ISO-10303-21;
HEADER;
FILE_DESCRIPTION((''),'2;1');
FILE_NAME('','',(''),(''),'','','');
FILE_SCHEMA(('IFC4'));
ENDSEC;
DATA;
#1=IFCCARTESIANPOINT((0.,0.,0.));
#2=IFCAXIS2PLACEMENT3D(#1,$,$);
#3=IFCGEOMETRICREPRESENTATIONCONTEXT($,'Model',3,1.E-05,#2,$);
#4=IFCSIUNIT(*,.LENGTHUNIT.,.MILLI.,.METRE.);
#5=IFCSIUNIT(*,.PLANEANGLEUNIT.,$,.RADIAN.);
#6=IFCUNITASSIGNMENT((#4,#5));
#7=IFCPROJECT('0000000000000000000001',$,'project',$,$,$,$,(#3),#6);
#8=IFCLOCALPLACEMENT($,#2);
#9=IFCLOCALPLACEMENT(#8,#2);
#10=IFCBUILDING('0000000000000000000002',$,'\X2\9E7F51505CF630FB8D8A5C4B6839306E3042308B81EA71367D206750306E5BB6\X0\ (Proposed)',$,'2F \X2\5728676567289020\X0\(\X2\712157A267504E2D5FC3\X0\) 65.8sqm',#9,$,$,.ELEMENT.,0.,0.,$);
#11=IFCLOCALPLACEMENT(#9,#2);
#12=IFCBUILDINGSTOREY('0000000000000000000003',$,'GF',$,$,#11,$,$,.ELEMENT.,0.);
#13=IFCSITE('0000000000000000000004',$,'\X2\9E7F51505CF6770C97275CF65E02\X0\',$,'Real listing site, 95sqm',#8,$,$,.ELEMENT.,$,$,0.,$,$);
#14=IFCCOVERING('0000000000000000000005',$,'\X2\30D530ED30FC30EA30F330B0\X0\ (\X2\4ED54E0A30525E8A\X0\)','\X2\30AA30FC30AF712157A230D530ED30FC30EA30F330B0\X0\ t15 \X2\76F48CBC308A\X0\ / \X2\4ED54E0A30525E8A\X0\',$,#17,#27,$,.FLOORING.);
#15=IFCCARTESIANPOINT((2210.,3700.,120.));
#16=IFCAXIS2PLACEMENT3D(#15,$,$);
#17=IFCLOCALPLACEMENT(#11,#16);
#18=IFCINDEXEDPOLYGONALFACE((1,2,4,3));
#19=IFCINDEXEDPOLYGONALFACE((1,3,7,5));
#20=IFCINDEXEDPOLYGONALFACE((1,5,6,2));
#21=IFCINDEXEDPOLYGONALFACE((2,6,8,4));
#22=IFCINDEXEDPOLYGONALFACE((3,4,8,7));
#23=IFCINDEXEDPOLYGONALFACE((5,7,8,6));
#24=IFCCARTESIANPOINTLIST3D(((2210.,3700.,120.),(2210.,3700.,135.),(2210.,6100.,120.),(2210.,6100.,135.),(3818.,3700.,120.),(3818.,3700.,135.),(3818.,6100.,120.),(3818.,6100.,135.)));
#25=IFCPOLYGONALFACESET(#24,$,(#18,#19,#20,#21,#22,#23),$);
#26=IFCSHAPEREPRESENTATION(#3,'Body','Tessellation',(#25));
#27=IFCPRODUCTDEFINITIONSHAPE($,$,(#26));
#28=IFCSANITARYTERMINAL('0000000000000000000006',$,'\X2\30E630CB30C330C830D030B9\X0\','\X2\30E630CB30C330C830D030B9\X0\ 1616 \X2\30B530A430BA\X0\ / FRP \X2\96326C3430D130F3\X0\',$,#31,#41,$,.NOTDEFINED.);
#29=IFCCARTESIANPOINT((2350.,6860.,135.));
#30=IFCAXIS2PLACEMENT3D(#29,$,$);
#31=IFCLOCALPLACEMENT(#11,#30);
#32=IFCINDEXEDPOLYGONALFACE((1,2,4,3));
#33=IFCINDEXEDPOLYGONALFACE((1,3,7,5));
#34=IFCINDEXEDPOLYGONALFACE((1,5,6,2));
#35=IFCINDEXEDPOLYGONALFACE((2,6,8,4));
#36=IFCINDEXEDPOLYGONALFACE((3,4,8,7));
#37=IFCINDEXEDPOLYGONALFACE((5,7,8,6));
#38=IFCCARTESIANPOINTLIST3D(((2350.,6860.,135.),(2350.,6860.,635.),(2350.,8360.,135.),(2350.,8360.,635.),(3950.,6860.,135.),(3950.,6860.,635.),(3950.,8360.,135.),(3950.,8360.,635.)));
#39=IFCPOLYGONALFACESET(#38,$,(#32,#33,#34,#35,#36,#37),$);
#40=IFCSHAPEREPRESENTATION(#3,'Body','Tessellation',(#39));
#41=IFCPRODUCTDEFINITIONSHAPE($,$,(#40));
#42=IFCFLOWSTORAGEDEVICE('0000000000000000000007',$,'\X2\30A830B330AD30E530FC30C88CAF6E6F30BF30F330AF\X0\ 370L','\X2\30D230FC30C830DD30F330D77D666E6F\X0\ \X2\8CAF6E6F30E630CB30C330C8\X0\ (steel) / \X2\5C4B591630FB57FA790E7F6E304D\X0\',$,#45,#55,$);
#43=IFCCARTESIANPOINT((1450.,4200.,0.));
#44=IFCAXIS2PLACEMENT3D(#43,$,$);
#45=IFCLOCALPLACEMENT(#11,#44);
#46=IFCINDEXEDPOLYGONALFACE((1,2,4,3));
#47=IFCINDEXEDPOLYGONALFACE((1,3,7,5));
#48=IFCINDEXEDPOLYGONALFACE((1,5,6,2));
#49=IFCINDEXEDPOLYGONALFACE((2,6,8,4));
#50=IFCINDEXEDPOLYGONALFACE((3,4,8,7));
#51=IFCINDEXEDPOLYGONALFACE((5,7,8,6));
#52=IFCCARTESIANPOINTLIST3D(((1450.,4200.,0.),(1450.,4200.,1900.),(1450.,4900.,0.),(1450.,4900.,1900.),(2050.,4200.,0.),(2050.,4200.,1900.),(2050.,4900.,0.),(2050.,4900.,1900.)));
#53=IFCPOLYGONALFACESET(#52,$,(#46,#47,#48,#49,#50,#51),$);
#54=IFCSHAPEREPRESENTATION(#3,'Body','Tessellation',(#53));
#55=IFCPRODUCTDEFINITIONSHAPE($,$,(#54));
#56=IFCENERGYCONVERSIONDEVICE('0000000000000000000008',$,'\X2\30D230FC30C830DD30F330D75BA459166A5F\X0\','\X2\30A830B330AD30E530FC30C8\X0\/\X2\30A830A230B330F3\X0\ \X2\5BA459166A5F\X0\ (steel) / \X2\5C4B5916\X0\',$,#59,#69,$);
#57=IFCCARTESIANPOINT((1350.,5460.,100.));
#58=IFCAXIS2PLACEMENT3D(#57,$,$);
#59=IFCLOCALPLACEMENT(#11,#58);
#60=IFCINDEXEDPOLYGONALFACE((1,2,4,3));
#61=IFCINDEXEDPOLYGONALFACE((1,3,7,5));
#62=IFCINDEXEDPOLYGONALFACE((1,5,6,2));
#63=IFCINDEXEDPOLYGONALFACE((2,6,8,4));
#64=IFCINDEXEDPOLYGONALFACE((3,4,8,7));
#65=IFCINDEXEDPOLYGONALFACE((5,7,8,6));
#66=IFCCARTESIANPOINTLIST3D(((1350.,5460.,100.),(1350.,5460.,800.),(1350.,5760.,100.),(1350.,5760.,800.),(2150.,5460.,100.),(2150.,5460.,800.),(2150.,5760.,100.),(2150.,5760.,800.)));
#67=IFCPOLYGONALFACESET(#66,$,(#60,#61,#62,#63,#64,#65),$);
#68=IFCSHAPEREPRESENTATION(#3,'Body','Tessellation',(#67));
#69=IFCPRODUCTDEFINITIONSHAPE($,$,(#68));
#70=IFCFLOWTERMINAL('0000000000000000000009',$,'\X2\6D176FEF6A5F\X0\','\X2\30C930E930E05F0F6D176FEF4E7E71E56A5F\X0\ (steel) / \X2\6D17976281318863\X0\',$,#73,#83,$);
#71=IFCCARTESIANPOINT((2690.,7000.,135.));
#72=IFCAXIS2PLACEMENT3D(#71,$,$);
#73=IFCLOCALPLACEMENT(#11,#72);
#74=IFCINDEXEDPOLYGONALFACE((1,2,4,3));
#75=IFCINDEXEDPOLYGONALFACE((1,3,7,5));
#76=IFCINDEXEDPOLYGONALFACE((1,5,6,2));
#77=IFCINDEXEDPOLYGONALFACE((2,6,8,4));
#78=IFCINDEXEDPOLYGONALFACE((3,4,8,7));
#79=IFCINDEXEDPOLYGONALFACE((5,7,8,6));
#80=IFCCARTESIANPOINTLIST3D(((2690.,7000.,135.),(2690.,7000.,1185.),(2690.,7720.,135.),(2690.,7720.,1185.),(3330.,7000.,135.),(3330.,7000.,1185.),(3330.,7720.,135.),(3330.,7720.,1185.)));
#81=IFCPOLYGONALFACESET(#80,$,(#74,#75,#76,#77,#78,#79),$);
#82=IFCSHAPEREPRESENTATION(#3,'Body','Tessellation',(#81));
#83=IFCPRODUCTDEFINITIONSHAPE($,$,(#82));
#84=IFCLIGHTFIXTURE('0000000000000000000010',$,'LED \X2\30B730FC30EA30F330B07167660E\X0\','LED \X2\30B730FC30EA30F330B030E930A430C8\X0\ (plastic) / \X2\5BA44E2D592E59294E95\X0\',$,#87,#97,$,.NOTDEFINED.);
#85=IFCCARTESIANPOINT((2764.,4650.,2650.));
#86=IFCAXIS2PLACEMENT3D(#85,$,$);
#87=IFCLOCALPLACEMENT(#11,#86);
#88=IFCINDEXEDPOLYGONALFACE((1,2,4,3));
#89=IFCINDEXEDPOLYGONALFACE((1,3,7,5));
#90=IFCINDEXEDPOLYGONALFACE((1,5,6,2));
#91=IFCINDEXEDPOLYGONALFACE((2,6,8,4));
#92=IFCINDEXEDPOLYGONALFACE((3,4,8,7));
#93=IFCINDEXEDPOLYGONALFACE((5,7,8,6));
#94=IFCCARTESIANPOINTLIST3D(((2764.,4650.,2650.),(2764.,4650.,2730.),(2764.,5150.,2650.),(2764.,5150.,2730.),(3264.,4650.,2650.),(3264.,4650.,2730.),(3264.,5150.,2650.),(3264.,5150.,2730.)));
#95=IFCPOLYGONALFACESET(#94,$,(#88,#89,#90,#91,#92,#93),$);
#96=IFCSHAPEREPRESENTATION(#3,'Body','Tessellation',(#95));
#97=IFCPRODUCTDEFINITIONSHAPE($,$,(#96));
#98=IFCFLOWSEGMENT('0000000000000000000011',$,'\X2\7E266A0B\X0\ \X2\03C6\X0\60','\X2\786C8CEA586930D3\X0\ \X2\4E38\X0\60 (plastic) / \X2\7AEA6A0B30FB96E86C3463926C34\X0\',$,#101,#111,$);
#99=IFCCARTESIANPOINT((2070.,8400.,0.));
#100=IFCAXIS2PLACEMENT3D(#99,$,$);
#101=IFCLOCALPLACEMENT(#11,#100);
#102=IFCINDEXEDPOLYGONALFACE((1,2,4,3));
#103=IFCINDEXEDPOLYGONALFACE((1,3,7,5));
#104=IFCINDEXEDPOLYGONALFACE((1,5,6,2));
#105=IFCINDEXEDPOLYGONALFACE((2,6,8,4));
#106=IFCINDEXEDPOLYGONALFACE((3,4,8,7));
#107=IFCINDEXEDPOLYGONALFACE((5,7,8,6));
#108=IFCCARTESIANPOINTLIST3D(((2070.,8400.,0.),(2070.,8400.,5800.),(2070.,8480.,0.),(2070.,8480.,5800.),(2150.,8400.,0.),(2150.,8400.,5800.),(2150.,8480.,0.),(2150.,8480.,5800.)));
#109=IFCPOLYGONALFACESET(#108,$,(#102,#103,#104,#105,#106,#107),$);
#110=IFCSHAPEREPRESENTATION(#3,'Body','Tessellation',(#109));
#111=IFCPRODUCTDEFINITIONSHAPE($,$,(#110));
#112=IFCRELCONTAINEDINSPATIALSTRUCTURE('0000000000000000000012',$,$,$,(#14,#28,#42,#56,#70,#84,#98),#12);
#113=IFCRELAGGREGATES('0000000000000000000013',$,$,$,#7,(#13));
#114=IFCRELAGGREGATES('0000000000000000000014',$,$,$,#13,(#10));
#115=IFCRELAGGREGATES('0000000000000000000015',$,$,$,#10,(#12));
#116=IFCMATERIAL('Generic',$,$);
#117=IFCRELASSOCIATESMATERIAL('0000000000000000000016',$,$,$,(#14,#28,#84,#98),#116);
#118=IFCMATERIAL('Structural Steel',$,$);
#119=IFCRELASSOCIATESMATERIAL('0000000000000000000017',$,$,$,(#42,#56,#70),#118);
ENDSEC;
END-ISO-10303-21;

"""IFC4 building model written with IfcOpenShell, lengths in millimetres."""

from ifc_helpers import new_model, si_unit, frame, frame_2d, origin, place, context, project, spatial, rectangle, extrude, material, element, save


model = new_model("IFC4")

# Units and contexts
model_context = context("Model", 3, precision=1e-05, world=origin())
ifc_project = project(units=[si_unit("LENGTHUNIT", "METRE", prefix="MILLI"), si_unit("PLANEANGLEUNIT", "RADIAN")], contexts=[model_context])

# Site, building, storey
site_placement = place(None, origin())
site = spatial("IfcSite", under=ifc_project, at=site_placement, Name="鹿児島県霧島市", ObjectType="Real listing site, 95sqm", CompositionType="ELEMENT", RefElevation=0.0)
building_placement = place(site_placement, origin())
building = spatial("IfcBuilding", under=site, at=building_placement, Name="鹿児島・越屋根のある自然素材の家 (Proposed)", ObjectType="2F 在来木造(無垢材中心) 65.8sqm", CompositionType="ELEMENT", ElevationOfRefHeight=0.0, ElevationOfTerrain=0.0)
storey_placement = place(building_placement, origin())
storey = spatial("IfcBuildingStorey", under=building, at=storey_placement, Name="GF", CompositionType="ELEMENT", Elevation=0.0)

# Covering
ifc_material_1 = material(Name="Generic")
covering_1_placement = place(storey_placement, frame((2210.0, 3700.0, 120.0)))
element("IfcCovering", 1, at=covering_1_placement, inside=storey, material=ifc_material_1, Name="フローリング (仕上げ床)", Description="オーク無垢フローリング t15 直貼り / 仕上げ床", PredefinedType="FLOORING", context=model_context, shape_type="SweptSolid", body=[
    extrude(rectangle(XDim=1608.0, YDim=2400.0, at=frame_2d((804.0, 1200.0))), frame((2210.0, 3700.0, 120.0)), (0.0, 0.0, 1.0), 15.0),
])

# Sanitary terminal
sanitary_terminal_placement = place(storey_placement, frame((2350.0, 6860.0, 135.0)))
element("IfcSanitaryTerminal", 2, at=sanitary_terminal_placement, inside=storey, material=ifc_material_1, Name="ユニットバス", Description="ユニットバス 1616 サイズ / FRP 防水パン", PredefinedType="NOTDEFINED", context=model_context, shape_type="SweptSolid", body=[
    extrude(rectangle(XDim=1600.0, YDim=1500.0, at=frame_2d((800.0, 750.0))), frame((2350.0, 6860.0, 135.0)), (0.0, 0.0, 1.0), 500.0),
])

# Flow storage device
ifc_material_2 = material(Name="Structural Steel")
flow_storage_device_placement = place(storey_placement, frame((1450.0, 4200.0, 0.0)))
element("IfcFlowStorageDevice", 3, at=flow_storage_device_placement, inside=storey, material=ifc_material_2, Name="エコキュート貯湯タンク 370L", Description="ヒートポンプ給湯 貯湯ユニット (steel) / 屋外・基礎置き", context=model_context, shape_type="SweptSolid", body=[
    extrude(rectangle(XDim=600.0, YDim=700.0, at=frame_2d((300.0, 350.0))), frame((1450.0, 4200.0, 0.0)), (0.0, 0.0, 1.0), 1900.0),
])

# Energy conversion device
energy_conversion_device_placement = place(storey_placement, frame((1350.0, 5460.0, 100.0)))
element("IfcEnergyConversionDevice", 4, at=energy_conversion_device_placement, inside=storey, material=ifc_material_2, Name="ヒートポンプ室外機", Description="エコキュート/エアコン 室外機 (steel) / 屋外", context=model_context, shape_type="SweptSolid", body=[
    extrude(rectangle(XDim=800.0, YDim=300.0, at=frame_2d((400.0, 150.0))), frame((1350.0, 5460.0, 100.0)), (0.0, 0.0, 1.0), 700.0),
])

# Flow terminal
flow_terminal_placement = place(storey_placement, frame((2690.0, 7000.0, 135.0)))
element("IfcFlowTerminal", 5, at=flow_terminal_placement, inside=storey, material=ifc_material_2, Name="洗濯機", Description="ドラム式洗濯乾燥機 (steel) / 洗面脱衣", context=model_context, shape_type="SweptSolid", body=[
    extrude(rectangle(XDim=640.0, YDim=720.0, at=frame_2d((320.0, 360.0))), frame((2690.0, 7000.0, 135.0)), (0.0, 0.0, 1.0), 1050.0),
])

# Light fixture
light_fixture_placement = place(storey_placement, frame((2764.0, 4650.0, 2650.0)))
element("IfcLightFixture", 6, at=light_fixture_placement, inside=storey, material=ifc_material_1, Name="LED シーリング照明", Description="LED シーリングライト (plastic) / 室中央天井", PredefinedType="NOTDEFINED", context=model_context, shape_type="SweptSolid", body=[
    extrude(rectangle(XDim=500.0, YDim=500.0, at=frame_2d((250.0, 250.0))), frame((2764.0, 4650.0, 2650.0)), (0.0, 0.0, 1.0), 80.0),
])

# Flow segment
flow_segment_placement = place(storey_placement, frame((2070.0, 8400.0, 0.0)))
element("IfcFlowSegment", 7, at=flow_segment_placement, inside=storey, material=ifc_material_1, Name="縦樋 φ60", Description="硬質塩ビ 丸60 (plastic) / 竪樋・雨水排水", context=model_context, shape_type="SweptSolid", body=[
    extrude(rectangle(XDim=80.0, YDim=80.0, at=frame_2d((40.0, 40.0))), frame((2070.0, 8400.0, 0.0)), (0.0, 0.0, 1.0), 5800.0),
])

save(model, "model.ifc")
